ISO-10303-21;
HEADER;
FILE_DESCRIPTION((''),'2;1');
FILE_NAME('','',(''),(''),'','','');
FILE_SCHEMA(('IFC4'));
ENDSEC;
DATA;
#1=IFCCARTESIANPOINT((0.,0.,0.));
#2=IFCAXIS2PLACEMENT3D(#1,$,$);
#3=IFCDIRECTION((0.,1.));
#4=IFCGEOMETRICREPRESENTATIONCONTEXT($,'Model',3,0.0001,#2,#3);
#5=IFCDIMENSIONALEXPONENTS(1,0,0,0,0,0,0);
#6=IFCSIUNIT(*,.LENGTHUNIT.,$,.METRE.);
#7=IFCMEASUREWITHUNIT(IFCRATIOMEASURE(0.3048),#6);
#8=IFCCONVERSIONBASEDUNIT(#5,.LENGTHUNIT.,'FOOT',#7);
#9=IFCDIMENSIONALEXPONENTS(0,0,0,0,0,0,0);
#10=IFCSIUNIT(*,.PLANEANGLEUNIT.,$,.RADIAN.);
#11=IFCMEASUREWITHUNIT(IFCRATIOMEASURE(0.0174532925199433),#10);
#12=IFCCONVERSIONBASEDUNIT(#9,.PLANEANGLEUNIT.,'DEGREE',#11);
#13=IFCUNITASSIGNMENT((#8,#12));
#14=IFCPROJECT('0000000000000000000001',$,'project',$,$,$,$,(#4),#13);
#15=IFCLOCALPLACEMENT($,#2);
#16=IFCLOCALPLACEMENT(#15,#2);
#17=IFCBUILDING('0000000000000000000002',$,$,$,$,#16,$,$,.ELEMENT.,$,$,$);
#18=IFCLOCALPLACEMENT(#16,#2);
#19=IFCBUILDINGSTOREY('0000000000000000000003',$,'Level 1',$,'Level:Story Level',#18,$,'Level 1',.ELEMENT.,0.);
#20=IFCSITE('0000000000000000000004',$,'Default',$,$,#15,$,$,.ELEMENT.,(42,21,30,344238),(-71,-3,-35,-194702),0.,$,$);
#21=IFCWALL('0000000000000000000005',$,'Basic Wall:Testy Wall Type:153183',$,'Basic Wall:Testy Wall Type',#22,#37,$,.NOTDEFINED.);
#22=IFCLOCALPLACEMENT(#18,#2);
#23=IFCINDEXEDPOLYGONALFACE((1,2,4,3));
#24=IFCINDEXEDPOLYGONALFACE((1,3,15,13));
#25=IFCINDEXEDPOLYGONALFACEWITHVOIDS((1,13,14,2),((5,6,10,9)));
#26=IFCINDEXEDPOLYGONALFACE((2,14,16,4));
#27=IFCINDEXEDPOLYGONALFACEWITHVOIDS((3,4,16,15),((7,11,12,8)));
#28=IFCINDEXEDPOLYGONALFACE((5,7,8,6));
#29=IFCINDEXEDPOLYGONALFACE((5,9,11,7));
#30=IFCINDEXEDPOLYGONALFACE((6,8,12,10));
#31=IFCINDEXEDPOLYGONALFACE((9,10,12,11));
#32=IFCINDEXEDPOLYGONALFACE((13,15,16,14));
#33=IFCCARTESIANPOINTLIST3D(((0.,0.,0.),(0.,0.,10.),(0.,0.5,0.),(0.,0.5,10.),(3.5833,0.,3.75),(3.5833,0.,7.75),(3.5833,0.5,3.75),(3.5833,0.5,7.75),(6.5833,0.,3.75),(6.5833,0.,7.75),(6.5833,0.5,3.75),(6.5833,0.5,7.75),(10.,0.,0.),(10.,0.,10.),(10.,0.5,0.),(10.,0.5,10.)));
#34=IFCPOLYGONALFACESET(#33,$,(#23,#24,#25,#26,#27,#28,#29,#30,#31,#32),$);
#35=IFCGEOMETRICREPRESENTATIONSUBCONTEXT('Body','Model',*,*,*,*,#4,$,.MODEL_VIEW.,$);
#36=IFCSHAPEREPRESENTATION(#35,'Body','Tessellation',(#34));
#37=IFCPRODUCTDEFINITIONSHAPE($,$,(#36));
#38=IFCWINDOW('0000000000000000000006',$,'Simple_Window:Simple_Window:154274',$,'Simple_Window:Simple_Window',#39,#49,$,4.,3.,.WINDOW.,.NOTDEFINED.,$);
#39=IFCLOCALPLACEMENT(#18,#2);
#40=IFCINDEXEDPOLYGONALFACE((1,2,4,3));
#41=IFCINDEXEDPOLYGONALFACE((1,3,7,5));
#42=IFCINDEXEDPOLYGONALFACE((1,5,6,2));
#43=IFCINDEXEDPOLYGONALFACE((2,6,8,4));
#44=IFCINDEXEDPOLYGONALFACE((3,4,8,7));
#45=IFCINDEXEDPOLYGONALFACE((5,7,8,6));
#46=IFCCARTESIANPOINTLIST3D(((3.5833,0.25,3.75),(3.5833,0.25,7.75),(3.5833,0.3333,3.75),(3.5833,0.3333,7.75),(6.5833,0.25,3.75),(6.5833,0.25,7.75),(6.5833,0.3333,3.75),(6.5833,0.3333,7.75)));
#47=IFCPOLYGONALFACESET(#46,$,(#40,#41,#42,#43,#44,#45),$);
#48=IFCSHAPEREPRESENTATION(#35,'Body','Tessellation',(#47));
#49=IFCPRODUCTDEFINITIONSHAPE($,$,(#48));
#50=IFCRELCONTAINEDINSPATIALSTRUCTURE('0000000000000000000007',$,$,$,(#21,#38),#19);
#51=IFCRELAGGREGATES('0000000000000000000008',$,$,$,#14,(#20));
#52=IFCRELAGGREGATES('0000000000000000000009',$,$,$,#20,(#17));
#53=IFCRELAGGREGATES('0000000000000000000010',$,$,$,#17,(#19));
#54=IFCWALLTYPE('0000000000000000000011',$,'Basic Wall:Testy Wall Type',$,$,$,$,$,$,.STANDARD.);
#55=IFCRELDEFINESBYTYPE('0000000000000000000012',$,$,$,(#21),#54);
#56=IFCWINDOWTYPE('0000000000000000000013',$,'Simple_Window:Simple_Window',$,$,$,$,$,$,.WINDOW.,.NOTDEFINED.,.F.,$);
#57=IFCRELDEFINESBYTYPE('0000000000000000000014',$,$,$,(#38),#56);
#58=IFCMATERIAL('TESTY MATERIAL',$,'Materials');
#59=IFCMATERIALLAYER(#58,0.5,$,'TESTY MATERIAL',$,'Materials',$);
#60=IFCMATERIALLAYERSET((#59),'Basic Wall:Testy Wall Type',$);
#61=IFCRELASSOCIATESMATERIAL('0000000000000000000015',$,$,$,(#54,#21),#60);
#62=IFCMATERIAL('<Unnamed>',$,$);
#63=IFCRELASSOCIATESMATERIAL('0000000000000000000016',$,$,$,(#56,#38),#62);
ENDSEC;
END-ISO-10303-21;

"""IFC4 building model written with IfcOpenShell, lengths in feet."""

from ifc_helpers import new_model, entity, si_unit, converted_unit, direction, frame, frame_2d, origin, origin_2d_with_axis, place, context, subcontext, project, spatial, rectangle, extrude, source, transform, mapped, material, layer, layer_set, layer_usage, type_object, type_shapes, element, fill, save


model = new_model("IFC4")

# Units and contexts
model_context = context("Model", 3, precision=0.0001, world=origin(), true_north=direction((0.0, 1.0)))
body_context = subcontext(model_context, "Body", "Model", "MODEL_VIEW")
ifc_project = project(units=[converted_unit("LENGTHUNIT", "FOOT", entity("IfcRatioMeasure", 0.3048), si_unit("LENGTHUNIT", "METRE"), dimensions=[1, 0, 0, 0, 0, 0, 0]), converted_unit("PLANEANGLEUNIT", "DEGREE", entity("IfcRatioMeasure", 0.0174532925199433), si_unit("PLANEANGLEUNIT", "RADIAN"), dimensions=[0, 0, 0, 0, 0, 0, 0])], contexts=[model_context])

# Site, building, storey
site_placement = place(None, origin())
site = spatial("IfcSite", under=ifc_project, at=site_placement, Name="Default", CompositionType="ELEMENT", RefLatitude=(42, 21, 30, 344238), RefLongitude=(-71, -3, -35, -194702), RefElevation=0.0)
building_placement = place(site_placement, origin())
building = spatial("IfcBuilding", under=site, at=building_placement, CompositionType="ELEMENT")
storey_placement = place(building_placement, origin())
storey = spatial("IfcBuildingStorey", under=building, at=storey_placement, Name="Level 1", ObjectType="Level:Story Level", LongName="Level 1", CompositionType="ELEMENT", Elevation=0.0)

# Wall, opening, window
ifc_material_1 = material(Name="TESTY MATERIAL", Category="Materials")
ifc_layer = layer(ifc_material_1, 0.5, Name="TESTY MATERIAL", Category="Materials")
ifc_layer_set = layer_set([ifc_layer], Name="Basic Wall:Testy Wall Type")
ifc_layer_usage = layer_usage(ifc_layer_set, "AXIS2", "NEGATIVE", 0.25)
wall_type = type_object("IfcWallType", Name="Basic Wall:Testy Wall Type", PredefinedType="STANDARD", material=ifc_layer_set)
wall_placement = place(storey_placement, frame((0.0, 0.25, 0.0)))
wall = element("IfcWall", 1, at=wall_placement, inside=storey, type_object=wall_type, material=ifc_layer_usage, Name="Basic Wall:Testy Wall Type:153183", ObjectType="Basic Wall:Testy Wall Type", PredefinedType="NOTDEFINED", context=body_context, shape_type="SweptSolid", body=[
    extrude(rectangle(XDim=10.0, YDim=0.5, at=frame_2d((5.0, 0.0), x_axis=(-1.0, 0.0))), origin(), (0.0, 0.0, 1.0), 10.0),
])
opening_placement = place(wall_placement, frame((6.5833, 0.25, 3.75)))
opening = element("IfcOpeningElement", 2, at=opening_placement, cuts=wall, PredefinedType="OPENING", context=body_context, shape_type="SweptSolid", body=[
    extrude(rectangle(XDim=4.0, YDim=3.0, at=frame_2d((2.0, 1.5), x_axis=(-1.0, 0.0))), frame((0.0, 0.0, 0.0), z_axis=(0.0, -1.0, 0.0), x_axis=(0.0, 0.0, 1.0)), (0.0, 0.0, 1.0), 0.5),
])
ifc_material_2 = material(Name="<Unnamed>")
window_type = type_object("IfcWindowType", Name="Simple_Window:Simple_Window", ParameterTakesPrecedence=False, PartitioningType="NOTDEFINED", PredefinedType="WINDOW", material=ifc_material_2)
shared_shape = source(origin(), body_context, "Body", "SweptSolid", [
    extrude(rectangle(XDim=0.0833, YDim=3.0, at=origin_2d_with_axis()), frame((1.5, 0.2083, 0.0), z_axis=(0.0, 0.0, 1.0), x_axis=(0.0, 1.0, 0.0)), (0.0, 0.0, 1.0), 4.0),
])
type_shapes(window_type, [shared_shape])
window_placement = place(opening_placement, frame((0.0, 0.0, 0.0), z_axis=(0.0, 0.0, 1.0), x_axis=(-1.0, 0.0, 0.0)))
window = element("IfcWindow", 3, at=window_placement, inside=storey, type_object=window_type, material=ifc_material_2, Name="Simple_Window:Simple_Window:154274", ObjectType="Simple_Window:Simple_Window", OverallHeight=4.0, OverallWidth=3.0, PartitioningType="NOTDEFINED", PredefinedType="WINDOW", context=body_context, shape_type="MappedRepresentation", body=[
    mapped(shared_shape, transform((0.0, 0.0, 0.0), scale=1.0)),
])
fill(opening, window)

save(model, "model.ifc")
